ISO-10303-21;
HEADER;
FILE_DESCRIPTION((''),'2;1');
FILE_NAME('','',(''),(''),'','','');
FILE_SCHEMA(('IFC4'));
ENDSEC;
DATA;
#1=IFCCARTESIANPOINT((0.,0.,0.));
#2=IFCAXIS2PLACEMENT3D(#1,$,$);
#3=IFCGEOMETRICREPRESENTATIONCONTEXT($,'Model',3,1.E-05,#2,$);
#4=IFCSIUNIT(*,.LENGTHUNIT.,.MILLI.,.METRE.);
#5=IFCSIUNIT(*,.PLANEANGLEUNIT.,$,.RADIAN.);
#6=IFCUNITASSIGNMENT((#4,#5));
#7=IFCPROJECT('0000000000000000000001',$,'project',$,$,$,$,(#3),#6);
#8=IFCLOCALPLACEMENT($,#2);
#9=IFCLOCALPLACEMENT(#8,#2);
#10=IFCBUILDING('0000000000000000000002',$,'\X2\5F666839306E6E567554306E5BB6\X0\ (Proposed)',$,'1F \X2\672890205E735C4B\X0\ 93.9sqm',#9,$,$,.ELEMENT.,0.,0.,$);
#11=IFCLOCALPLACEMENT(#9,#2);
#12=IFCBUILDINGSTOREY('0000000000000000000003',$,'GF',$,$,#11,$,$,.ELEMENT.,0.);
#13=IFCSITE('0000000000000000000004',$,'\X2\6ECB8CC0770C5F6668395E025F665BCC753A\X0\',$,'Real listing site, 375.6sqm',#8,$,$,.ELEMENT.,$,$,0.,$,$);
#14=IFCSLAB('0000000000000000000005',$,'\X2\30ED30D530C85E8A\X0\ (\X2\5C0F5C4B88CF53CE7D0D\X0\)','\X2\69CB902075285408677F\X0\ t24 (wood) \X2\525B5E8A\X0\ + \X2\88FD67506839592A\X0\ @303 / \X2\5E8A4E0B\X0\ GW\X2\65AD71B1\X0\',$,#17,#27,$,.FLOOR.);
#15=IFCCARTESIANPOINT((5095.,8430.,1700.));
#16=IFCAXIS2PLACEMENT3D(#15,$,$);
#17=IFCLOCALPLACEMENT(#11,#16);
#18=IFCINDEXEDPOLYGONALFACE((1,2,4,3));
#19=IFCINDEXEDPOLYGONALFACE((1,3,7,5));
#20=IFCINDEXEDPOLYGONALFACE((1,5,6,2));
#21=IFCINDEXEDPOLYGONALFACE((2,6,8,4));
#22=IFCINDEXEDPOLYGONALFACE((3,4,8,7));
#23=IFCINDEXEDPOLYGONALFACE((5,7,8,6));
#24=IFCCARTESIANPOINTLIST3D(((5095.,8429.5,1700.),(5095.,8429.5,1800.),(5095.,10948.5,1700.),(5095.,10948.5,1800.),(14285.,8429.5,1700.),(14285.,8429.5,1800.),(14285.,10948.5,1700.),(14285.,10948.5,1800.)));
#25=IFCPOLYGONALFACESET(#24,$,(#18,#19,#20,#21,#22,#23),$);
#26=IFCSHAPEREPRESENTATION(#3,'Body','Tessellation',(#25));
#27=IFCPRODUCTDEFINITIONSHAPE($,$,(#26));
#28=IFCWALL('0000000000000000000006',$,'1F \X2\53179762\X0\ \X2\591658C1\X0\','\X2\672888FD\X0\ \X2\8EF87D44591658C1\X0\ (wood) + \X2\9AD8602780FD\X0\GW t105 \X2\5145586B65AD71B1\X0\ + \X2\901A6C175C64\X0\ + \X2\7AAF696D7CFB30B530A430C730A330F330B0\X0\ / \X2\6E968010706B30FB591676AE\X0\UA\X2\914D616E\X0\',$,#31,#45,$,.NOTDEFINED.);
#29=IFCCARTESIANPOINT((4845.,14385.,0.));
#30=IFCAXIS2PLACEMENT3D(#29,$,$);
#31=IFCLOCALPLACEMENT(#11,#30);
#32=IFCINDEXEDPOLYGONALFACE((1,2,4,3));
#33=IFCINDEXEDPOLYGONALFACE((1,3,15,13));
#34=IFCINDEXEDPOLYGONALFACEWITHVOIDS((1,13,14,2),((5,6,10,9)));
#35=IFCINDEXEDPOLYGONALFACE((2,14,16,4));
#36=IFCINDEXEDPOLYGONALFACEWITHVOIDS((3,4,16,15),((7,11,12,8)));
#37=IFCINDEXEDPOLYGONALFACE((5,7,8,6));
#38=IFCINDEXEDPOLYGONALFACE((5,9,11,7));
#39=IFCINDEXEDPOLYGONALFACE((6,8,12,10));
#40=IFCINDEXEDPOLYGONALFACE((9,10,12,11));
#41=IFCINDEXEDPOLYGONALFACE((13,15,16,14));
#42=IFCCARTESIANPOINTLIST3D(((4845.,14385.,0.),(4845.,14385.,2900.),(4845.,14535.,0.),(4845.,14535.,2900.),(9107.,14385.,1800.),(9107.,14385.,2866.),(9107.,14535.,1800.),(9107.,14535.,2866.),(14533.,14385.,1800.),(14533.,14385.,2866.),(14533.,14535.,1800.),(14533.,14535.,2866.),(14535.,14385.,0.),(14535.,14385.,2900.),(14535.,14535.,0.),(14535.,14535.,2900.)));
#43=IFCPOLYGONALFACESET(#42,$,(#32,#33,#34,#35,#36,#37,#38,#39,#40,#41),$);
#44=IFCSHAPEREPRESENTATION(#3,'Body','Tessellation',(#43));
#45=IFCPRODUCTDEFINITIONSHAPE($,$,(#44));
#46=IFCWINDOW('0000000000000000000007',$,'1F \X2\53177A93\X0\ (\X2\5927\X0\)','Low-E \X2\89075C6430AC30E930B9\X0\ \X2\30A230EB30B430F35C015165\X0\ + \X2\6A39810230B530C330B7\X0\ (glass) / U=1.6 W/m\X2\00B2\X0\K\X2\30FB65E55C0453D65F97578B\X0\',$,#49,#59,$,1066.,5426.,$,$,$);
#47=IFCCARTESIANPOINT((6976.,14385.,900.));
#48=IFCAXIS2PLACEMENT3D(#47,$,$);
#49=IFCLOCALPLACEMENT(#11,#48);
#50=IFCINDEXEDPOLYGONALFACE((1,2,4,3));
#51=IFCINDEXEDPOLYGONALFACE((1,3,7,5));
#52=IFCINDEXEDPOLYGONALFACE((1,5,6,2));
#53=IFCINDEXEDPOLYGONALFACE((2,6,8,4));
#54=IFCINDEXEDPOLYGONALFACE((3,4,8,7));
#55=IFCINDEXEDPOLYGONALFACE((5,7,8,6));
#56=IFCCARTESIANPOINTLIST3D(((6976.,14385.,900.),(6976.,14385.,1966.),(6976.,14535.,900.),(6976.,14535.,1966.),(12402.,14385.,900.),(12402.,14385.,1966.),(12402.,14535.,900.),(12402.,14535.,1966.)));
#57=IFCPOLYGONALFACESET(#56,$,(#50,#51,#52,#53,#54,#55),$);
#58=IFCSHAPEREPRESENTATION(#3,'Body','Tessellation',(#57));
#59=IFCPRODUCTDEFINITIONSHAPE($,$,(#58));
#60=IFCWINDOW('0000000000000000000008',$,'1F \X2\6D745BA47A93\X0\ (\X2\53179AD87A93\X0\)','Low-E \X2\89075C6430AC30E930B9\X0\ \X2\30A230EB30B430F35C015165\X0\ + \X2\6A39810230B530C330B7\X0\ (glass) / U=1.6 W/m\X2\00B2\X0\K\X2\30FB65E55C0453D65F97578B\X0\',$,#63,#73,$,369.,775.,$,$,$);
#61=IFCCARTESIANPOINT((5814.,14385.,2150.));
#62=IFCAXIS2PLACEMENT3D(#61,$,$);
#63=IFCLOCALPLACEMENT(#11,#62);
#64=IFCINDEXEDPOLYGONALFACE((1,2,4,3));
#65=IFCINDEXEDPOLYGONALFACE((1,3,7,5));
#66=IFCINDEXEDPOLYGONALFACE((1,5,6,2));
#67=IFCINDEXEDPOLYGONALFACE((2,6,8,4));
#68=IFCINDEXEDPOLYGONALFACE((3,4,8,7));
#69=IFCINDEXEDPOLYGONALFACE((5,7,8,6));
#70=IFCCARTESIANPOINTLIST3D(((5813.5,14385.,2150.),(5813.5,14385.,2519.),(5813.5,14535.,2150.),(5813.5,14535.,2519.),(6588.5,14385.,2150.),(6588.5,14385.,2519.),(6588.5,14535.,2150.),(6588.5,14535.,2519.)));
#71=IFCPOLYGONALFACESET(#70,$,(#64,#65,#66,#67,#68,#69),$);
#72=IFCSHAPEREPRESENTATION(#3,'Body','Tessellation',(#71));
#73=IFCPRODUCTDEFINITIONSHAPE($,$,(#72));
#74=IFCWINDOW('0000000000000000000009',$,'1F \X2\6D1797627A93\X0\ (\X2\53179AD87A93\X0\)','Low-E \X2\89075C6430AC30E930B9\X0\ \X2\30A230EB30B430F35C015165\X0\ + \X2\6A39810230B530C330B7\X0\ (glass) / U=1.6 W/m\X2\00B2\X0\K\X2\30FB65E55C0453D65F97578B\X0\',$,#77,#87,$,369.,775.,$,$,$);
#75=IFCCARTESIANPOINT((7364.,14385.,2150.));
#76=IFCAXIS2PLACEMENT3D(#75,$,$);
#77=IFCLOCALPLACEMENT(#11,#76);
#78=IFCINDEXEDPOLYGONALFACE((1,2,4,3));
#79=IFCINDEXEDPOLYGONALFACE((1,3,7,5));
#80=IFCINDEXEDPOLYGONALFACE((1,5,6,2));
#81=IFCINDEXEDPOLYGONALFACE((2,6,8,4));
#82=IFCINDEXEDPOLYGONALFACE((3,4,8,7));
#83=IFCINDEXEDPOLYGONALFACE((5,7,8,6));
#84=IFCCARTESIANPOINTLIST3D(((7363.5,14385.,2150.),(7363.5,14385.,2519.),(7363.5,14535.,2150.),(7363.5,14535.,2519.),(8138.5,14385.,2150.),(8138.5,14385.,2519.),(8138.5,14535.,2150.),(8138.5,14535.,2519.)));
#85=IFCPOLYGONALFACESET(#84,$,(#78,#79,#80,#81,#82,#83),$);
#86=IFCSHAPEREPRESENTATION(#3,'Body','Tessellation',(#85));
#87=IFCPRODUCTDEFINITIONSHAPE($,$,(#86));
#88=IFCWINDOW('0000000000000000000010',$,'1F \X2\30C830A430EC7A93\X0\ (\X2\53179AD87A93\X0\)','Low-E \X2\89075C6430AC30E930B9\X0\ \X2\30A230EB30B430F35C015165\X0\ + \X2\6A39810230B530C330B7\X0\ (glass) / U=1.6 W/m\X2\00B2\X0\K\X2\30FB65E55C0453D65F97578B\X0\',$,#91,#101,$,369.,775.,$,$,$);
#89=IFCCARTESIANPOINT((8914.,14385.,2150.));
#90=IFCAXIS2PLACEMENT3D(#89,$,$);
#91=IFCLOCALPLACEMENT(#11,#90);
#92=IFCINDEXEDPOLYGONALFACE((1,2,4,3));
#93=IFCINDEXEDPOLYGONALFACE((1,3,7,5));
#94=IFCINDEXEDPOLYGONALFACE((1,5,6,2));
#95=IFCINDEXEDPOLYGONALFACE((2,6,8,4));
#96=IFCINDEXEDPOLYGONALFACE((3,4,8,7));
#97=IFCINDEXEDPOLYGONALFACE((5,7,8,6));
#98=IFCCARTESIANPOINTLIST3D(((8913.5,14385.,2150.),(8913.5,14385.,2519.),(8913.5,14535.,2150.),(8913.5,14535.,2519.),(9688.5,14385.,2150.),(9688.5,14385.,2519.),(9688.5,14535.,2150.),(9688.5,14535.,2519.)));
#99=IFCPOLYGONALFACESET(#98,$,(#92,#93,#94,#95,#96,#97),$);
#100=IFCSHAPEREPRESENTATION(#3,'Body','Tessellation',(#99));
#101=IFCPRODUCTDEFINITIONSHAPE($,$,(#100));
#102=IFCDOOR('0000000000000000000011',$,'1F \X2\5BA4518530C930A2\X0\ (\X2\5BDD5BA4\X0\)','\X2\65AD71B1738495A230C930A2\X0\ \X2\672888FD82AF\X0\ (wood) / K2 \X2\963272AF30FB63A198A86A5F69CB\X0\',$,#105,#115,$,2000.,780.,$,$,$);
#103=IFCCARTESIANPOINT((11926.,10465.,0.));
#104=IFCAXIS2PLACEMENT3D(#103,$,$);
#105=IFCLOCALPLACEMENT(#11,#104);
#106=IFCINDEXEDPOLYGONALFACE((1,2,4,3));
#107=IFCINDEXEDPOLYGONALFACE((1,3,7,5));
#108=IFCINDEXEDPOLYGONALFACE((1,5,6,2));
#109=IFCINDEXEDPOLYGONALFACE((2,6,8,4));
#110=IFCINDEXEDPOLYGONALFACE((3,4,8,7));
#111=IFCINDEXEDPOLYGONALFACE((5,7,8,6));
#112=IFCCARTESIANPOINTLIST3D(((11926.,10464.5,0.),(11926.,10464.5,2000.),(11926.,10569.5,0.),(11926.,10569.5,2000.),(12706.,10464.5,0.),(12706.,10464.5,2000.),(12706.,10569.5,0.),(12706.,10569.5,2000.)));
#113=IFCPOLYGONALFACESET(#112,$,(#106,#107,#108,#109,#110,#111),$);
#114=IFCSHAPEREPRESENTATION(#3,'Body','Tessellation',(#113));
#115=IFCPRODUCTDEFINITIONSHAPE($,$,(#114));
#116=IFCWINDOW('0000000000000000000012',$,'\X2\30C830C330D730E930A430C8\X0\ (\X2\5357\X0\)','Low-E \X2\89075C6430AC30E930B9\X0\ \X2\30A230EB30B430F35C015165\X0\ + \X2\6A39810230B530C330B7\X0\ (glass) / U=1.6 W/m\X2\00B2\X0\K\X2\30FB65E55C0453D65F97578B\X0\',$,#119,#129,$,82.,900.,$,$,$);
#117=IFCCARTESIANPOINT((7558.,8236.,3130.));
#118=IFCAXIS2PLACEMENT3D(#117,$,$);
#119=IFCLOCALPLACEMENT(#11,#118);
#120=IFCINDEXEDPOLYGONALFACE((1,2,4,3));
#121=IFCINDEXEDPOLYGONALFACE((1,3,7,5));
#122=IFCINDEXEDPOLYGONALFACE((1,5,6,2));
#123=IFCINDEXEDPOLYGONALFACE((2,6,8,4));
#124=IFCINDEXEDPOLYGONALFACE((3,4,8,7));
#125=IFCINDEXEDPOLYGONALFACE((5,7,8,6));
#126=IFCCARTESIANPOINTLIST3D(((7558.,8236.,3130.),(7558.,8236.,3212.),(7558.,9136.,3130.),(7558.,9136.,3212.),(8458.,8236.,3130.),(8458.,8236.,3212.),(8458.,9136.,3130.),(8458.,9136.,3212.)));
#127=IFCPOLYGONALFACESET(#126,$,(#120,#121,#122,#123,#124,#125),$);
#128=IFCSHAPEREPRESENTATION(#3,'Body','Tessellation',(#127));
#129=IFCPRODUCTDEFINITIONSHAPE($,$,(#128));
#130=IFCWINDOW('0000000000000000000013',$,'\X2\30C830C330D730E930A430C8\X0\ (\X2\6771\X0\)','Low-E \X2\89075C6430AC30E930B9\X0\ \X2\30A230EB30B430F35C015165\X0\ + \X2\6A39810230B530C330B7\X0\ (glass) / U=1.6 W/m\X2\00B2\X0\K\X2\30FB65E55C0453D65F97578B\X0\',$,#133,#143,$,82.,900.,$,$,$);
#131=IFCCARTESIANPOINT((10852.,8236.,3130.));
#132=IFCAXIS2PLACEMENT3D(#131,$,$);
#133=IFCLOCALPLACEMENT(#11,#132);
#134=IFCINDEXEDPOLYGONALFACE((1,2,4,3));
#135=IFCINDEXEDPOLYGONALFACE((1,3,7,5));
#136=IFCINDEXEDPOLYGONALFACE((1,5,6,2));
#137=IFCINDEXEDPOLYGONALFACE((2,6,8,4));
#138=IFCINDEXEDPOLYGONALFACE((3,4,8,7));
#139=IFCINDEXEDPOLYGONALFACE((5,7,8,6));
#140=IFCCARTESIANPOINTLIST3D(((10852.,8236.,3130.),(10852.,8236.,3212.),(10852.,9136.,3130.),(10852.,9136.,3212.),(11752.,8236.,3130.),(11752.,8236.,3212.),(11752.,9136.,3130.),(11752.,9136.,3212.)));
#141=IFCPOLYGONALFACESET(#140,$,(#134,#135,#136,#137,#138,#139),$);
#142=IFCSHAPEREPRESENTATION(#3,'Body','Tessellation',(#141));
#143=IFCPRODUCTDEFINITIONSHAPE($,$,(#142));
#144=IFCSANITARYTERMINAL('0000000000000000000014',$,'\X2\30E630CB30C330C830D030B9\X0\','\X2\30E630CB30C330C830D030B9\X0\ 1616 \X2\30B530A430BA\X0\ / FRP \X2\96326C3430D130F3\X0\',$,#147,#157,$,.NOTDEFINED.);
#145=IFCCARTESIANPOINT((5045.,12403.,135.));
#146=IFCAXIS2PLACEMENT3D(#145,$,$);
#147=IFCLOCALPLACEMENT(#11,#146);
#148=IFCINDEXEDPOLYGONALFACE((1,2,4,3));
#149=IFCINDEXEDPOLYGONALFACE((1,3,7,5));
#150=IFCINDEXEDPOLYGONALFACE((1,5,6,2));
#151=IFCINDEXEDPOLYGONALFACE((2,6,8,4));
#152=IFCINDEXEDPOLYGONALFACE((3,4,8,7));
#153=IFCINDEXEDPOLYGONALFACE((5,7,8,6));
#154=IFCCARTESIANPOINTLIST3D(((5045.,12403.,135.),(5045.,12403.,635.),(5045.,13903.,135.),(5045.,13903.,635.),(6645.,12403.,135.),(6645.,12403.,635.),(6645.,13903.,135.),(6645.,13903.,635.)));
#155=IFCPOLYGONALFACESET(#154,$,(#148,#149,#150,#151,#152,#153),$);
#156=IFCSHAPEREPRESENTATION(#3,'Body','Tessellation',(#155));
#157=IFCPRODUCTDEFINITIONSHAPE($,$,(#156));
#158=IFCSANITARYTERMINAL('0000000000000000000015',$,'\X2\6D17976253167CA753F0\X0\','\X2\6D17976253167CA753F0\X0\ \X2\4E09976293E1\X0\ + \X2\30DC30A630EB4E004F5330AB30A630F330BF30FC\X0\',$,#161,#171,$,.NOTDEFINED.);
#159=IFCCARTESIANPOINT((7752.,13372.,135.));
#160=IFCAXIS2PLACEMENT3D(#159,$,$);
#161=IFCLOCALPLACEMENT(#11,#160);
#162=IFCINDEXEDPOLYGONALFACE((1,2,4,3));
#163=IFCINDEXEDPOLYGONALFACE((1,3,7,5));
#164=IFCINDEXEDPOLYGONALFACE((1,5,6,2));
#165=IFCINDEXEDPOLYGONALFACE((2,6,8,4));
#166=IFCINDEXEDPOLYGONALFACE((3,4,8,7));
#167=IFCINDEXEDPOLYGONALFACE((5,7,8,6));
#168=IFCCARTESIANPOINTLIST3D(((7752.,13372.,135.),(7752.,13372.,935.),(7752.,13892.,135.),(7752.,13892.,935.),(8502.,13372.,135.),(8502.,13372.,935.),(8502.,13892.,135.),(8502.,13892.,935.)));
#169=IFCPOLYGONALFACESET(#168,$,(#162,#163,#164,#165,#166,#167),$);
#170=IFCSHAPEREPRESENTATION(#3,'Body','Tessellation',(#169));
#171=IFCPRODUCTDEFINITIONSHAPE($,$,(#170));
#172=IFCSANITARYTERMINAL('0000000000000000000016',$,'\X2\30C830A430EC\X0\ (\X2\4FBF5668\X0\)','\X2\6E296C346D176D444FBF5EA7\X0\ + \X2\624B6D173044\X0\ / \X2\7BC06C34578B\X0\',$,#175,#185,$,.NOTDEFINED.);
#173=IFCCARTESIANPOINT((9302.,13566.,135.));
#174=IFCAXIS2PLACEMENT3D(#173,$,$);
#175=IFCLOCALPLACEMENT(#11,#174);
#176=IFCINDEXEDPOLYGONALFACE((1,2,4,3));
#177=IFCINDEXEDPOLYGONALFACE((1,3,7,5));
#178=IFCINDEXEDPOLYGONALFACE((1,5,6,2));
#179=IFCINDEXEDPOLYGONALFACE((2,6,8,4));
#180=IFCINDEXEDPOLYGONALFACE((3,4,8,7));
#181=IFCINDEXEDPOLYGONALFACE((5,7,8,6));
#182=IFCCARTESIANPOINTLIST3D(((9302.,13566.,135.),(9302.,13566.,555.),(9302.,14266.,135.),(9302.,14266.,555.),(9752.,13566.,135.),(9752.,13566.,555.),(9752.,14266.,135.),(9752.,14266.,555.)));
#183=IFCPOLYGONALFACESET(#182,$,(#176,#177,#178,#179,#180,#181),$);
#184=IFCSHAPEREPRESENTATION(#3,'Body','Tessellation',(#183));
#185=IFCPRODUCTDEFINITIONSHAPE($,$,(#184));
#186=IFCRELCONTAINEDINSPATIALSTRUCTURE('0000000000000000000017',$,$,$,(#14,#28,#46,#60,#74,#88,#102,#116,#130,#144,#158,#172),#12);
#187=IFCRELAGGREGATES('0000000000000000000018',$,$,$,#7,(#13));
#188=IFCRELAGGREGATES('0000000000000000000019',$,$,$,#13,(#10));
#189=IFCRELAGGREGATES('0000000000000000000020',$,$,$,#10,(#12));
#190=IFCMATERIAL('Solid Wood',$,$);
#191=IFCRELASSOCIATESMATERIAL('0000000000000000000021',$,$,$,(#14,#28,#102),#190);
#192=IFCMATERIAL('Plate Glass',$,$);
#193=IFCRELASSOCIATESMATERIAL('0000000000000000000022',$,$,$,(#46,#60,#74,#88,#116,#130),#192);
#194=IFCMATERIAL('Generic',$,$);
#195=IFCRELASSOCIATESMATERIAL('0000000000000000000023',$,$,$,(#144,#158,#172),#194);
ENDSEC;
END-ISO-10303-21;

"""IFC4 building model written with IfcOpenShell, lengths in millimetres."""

from ifc_helpers import new_model, si_unit, frame, frame_2d, origin, place, context, project, spatial, rectangle, extrude, material, element, fill, save


model = new_model("IFC4")

# Units and contexts
model_context = context("Model", 3, precision=1e-05, world=origin())
ifc_project = project(units=[si_unit("LENGTHUNIT", "METRE", prefix="MILLI"), si_unit("PLANEANGLEUNIT", "RADIAN")], contexts=[model_context])

# Site, building, storey
site_placement = place(None, origin())
site = spatial("IfcSite", under=ifc_project, at=site_placement, Name="滋賀県彦根市彦富町", ObjectType="Real listing site, 375.6sqm", CompositionType="ELEMENT", RefElevation=0.0)
building_placement = place(site_placement, origin())
building = spatial("IfcBuilding", under=site, at=building_placement, Name="彦根の湖畔の家 (Proposed)", ObjectType="1F 木造平屋 93.9sqm", CompositionType="ELEMENT", ElevationOfRefHeight=0.0, ElevationOfTerrain=0.0)
storey_placement = place(building_placement, origin())
storey = spatial("IfcBuildingStorey", under=building, at=storey_placement, Name="GF", CompositionType="ELEMENT", Elevation=0.0)

# Slab
ifc_material_1 = material(Name="Solid Wood")
slab_placement = place(storey_placement, frame((5095.0, 8430.0, 1700.0)))
element("IfcSlab", 1, at=slab_placement, inside=storey, material=ifc_material_1, Name="ロフト床 (小屋裏収納)", Description="構造用合板 t24 (wood) 剛床 + 製材根太 @303 / 床下 GW断熱", PredefinedType="FLOOR", context=model_context, shape_type="SweptSolid", body=[
    extrude(rectangle(XDim=9190.0, YDim=2519.0, at=frame_2d((4595.0, 1259.0))), frame((5095.0, 8430.0, 1700.0)), (0.0, 0.0, 1.0), 100.0),
])

# Wall, openings, windows
wall_1_placement = place(storey_placement, frame((4845.0, 14385.0, 0.0)))
wall_1 = element("IfcWall", 2, at=wall_1_placement, inside=storey, material=ifc_material_1, Name="1F 北面 外壁", Description="木製 軸組外壁 (wood) + 高性能GW t105 充填断熱 + 通気層 + 窯業系サイディング / 準耐火・外皮UA配慮", PredefinedType="NOTDEFINED", context=model_context, shape_type="SweptSolid", body=[
    extrude(rectangle(XDim=9690.0, YDim=150.0, at=frame_2d((4845.0, 75.0))), frame((4845.0, 14385.0, 0.0)), (0.0, 0.0, 1.0), 2900.0),
])
opening_1_placement = place(storey_placement, frame((6976.0, 14385.0, 900.0)))
opening_1 = element("IfcOpeningElement", 3, at=opening_1_placement, cuts=wall_1, PredefinedType="NOTDEFINED", context=model_context, shape_type="SweptSolid", body=[
    extrude(rectangle(XDim=5426.0, YDim=150.0, at=frame_2d((2713.0, 75.0))), frame((6976.0, 14385.0, 900.0)), (0.0, 0.0, 1.0), 1066.0),
])
opening_2_placement = place(storey_placement, frame((5814.0, 14385.0, 2150.0)))
opening_2 = element("IfcOpeningElement", 4, at=opening_2_placement, cuts=wall_1, PredefinedType="NOTDEFINED", context=model_context, shape_type="SweptSolid", body=[
    extrude(rectangle(XDim=775.0, YDim=150.0, at=frame_2d((387.0, 75.0))), frame((5814.0, 14385.0, 2150.0)), (0.0, 0.0, 1.0), 369.0),
])
opening_3_placement = place(storey_placement, frame((7364.0, 14385.0, 2150.0)))
opening_3 = element("IfcOpeningElement", 5, at=opening_3_placement, cuts=wall_1, PredefinedType="NOTDEFINED", context=model_context, shape_type="SweptSolid", body=[
    extrude(rectangle(XDim=775.0, YDim=150.0, at=frame_2d((387.0, 75.0))), frame((7364.0, 14385.0, 2150.0)), (0.0, 0.0, 1.0), 369.0),
])
opening_4_placement = place(storey_placement, frame((8914.0, 14385.0, 2150.0)))
opening_4 = element("IfcOpeningElement", 6, at=opening_4_placement, cuts=wall_1, PredefinedType="NOTDEFINED", context=model_context, shape_type="SweptSolid", body=[
    extrude(rectangle(XDim=775.0, YDim=150.0, at=frame_2d((387.0, 75.0))), frame((8914.0, 14385.0, 2150.0)), (0.0, 0.0, 1.0), 369.0),
])
ifc_material_2 = material(Name="Plate Glass")
window_1_placement = place(storey_placement, frame((6976.0, 14385.0, 900.0)))
window_1 = element("IfcWindow", 7, at=window_1_placement, inside=storey, material=ifc_material_2, Name="1F 北窓 (大)", Description="Low-E 複層ガラス アルゴン封入 + 樹脂サッシ (glass) / U=1.6 W/m²K・日射取得型", OverallHeight=1066.0, OverallWidth=5426.0, context=model_context, shape_type="SweptSolid", body=[
    extrude(rectangle(XDim=5426.0, YDim=150.0, at=frame_2d((2713.0, 75.0))), frame((6976.0, 14385.0, 900.0)), (0.0, 0.0, 1.0), 1066.0),
])
fill(opening_1, window_1)
window_2_placement = place(storey_placement, frame((5814.0, 14385.0, 2150.0)))
window_2 = element("IfcWindow", 8, at=window_2_placement, inside=storey, material=ifc_material_2, Name="1F 浴室窓 (北高窓)", Description="Low-E 複層ガラス アルゴン封入 + 樹脂サッシ (glass) / U=1.6 W/m²K・日射取得型", OverallHeight=369.0, OverallWidth=775.0, context=model_context, shape_type="SweptSolid", body=[
    extrude(rectangle(XDim=775.0, YDim=150.0, at=frame_2d((387.0, 75.0))), frame((5814.0, 14385.0, 2150.0)), (0.0, 0.0, 1.0), 369.0),
])
fill(opening_2, window_2)
window_3_placement = place(storey_placement, frame((7364.0, 14385.0, 2150.0)))
window_3 = element("IfcWindow", 9, at=window_3_placement, inside=storey, material=ifc_material_2, Name="1F 洗面窓 (北高窓)", Description="Low-E 複層ガラス アルゴン封入 + 樹脂サッシ (glass) / U=1.6 W/m²K・日射取得型", OverallHeight=369.0, OverallWidth=775.0, context=model_context, shape_type="SweptSolid", body=[
    extrude(rectangle(XDim=775.0, YDim=150.0, at=frame_2d((387.0, 75.0))), frame((7364.0, 14385.0, 2150.0)), (0.0, 0.0, 1.0), 369.0),
])
fill(opening_3, window_3)
window_4_placement = place(storey_placement, frame((8914.0, 14385.0, 2150.0)))
window_4 = element("IfcWindow", 10, at=window_4_placement, inside=storey, material=ifc_material_2, Name="1F トイレ窓 (北高窓)", Description="Low-E 複層ガラス アルゴン封入 + 樹脂サッシ (glass) / U=1.6 W/m²K・日射取得型", OverallHeight=369.0, OverallWidth=775.0, context=model_context, shape_type="SweptSolid", body=[
    extrude(rectangle(XDim=775.0, YDim=150.0, at=frame_2d((387.0, 75.0))), frame((8914.0, 14385.0, 2150.0)), (0.0, 0.0, 1.0), 369.0),
])
fill(opening_4, window_4)

# Door
door_1_placement = place(storey_placement, frame((11926.0, 10465.0, 0.0)))
element("IfcDoor", 11, at=door_1_placement, inside=storey, material=ifc_material_1, Name="1F 室内ドア (寝室)", Description="断熱玄関ドア 木製芯 (wood) / K2 防犯・採風機構", OverallHeight=2000.0, OverallWidth=780.0, context=model_context, shape_type="SweptSolid", body=[
    extrude(rectangle(XDim=780.0, YDim=105.0, at=frame_2d((390.0, 52.0))), frame((11926.0, 10465.0, 0.0)), (0.0, 0.0, 1.0), 2000.0),
])

# Windows
window_5_placement = place(storey_placement, frame((7558.0, 8236.0, 3130.0)))
element("IfcWindow", 12, at=window_5_placement, inside=storey, material=ifc_material_2, Name="トップライト (南)", Description="Low-E 複層ガラス アルゴン封入 + 樹脂サッシ (glass) / U=1.6 W/m²K・日射取得型", OverallHeight=82.0, OverallWidth=900.0, context=model_context, shape_type="SweptSolid", body=[
    extrude(rectangle(XDim=900.0, YDim=900.0, at=frame_2d((450.0, 450.0))), frame((7558.0, 8236.0, 3130.0)), (0.0, 0.0, 1.0), 82.0),
])
window_6_placement = place(storey_placement, frame((10852.0, 8236.0, 3130.0)))
element("IfcWindow", 13, at=window_6_placement, inside=storey, material=ifc_material_2, Name="トップライト (東)", Description="Low-E 複層ガラス アルゴン封入 + 樹脂サッシ (glass) / U=1.6 W/m²K・日射取得型", OverallHeight=82.0, OverallWidth=900.0, context=model_context, shape_type="SweptSolid", body=[
    extrude(rectangle(XDim=900.0, YDim=900.0, at=frame_2d((450.0, 450.0))), frame((10852.0, 8236.0, 3130.0)), (0.0, 0.0, 1.0), 82.0),
])

# Sanitary terminals
ifc_material_3 = material(Name="Generic")
sanitary_terminal_1_placement = place(storey_placement, frame((5045.0, 12403.0, 135.0)))
element("IfcSanitaryTerminal", 14, at=sanitary_terminal_1_placement, inside=storey, material=ifc_material_3, Name="ユニットバス", Description="ユニットバス 1616 サイズ / FRP 防水パン", PredefinedType="NOTDEFINED", context=model_context, shape_type="SweptSolid", body=[
    extrude(rectangle(XDim=1600.0, YDim=1500.0, at=frame_2d((800.0, 750.0))), frame((5045.0, 12403.0, 135.0)), (0.0, 0.0, 1.0), 500.0),
])
sanitary_terminal_2_placement = place(storey_placement, frame((7752.0, 13372.0, 135.0)))
element("IfcSanitaryTerminal", 15, at=sanitary_terminal_2_placement, inside=storey, material=ifc_material_3, Name="洗面化粧台", Description="洗面化粧台 三面鏡 + ボウル一体カウンター", PredefinedType="NOTDEFINED", context=model_context, shape_type="SweptSolid", body=[
    extrude(rectangle(XDim=750.0, YDim=520.0, at=frame_2d((375.0, 260.0))), frame((7752.0, 13372.0, 135.0)), (0.0, 0.0, 1.0), 800.0),
])
sanitary_terminal_3_placement = place(storey_placement, frame((9302.0, 13566.0, 135.0)))
element("IfcSanitaryTerminal", 16, at=sanitary_terminal_3_placement, inside=storey, material=ifc_material_3, Name="トイレ (便器)", Description="温水洗浄便座 + 手洗い / 節水型", PredefinedType="NOTDEFINED", context=model_context, shape_type="SweptSolid", body=[
    extrude(rectangle(XDim=450.0, YDim=700.0, at=frame_2d((225.0, 350.0))), frame((9302.0, 13566.0, 135.0)), (0.0, 0.0, 1.0), 420.0),
])

save(model, "model.ifc")
